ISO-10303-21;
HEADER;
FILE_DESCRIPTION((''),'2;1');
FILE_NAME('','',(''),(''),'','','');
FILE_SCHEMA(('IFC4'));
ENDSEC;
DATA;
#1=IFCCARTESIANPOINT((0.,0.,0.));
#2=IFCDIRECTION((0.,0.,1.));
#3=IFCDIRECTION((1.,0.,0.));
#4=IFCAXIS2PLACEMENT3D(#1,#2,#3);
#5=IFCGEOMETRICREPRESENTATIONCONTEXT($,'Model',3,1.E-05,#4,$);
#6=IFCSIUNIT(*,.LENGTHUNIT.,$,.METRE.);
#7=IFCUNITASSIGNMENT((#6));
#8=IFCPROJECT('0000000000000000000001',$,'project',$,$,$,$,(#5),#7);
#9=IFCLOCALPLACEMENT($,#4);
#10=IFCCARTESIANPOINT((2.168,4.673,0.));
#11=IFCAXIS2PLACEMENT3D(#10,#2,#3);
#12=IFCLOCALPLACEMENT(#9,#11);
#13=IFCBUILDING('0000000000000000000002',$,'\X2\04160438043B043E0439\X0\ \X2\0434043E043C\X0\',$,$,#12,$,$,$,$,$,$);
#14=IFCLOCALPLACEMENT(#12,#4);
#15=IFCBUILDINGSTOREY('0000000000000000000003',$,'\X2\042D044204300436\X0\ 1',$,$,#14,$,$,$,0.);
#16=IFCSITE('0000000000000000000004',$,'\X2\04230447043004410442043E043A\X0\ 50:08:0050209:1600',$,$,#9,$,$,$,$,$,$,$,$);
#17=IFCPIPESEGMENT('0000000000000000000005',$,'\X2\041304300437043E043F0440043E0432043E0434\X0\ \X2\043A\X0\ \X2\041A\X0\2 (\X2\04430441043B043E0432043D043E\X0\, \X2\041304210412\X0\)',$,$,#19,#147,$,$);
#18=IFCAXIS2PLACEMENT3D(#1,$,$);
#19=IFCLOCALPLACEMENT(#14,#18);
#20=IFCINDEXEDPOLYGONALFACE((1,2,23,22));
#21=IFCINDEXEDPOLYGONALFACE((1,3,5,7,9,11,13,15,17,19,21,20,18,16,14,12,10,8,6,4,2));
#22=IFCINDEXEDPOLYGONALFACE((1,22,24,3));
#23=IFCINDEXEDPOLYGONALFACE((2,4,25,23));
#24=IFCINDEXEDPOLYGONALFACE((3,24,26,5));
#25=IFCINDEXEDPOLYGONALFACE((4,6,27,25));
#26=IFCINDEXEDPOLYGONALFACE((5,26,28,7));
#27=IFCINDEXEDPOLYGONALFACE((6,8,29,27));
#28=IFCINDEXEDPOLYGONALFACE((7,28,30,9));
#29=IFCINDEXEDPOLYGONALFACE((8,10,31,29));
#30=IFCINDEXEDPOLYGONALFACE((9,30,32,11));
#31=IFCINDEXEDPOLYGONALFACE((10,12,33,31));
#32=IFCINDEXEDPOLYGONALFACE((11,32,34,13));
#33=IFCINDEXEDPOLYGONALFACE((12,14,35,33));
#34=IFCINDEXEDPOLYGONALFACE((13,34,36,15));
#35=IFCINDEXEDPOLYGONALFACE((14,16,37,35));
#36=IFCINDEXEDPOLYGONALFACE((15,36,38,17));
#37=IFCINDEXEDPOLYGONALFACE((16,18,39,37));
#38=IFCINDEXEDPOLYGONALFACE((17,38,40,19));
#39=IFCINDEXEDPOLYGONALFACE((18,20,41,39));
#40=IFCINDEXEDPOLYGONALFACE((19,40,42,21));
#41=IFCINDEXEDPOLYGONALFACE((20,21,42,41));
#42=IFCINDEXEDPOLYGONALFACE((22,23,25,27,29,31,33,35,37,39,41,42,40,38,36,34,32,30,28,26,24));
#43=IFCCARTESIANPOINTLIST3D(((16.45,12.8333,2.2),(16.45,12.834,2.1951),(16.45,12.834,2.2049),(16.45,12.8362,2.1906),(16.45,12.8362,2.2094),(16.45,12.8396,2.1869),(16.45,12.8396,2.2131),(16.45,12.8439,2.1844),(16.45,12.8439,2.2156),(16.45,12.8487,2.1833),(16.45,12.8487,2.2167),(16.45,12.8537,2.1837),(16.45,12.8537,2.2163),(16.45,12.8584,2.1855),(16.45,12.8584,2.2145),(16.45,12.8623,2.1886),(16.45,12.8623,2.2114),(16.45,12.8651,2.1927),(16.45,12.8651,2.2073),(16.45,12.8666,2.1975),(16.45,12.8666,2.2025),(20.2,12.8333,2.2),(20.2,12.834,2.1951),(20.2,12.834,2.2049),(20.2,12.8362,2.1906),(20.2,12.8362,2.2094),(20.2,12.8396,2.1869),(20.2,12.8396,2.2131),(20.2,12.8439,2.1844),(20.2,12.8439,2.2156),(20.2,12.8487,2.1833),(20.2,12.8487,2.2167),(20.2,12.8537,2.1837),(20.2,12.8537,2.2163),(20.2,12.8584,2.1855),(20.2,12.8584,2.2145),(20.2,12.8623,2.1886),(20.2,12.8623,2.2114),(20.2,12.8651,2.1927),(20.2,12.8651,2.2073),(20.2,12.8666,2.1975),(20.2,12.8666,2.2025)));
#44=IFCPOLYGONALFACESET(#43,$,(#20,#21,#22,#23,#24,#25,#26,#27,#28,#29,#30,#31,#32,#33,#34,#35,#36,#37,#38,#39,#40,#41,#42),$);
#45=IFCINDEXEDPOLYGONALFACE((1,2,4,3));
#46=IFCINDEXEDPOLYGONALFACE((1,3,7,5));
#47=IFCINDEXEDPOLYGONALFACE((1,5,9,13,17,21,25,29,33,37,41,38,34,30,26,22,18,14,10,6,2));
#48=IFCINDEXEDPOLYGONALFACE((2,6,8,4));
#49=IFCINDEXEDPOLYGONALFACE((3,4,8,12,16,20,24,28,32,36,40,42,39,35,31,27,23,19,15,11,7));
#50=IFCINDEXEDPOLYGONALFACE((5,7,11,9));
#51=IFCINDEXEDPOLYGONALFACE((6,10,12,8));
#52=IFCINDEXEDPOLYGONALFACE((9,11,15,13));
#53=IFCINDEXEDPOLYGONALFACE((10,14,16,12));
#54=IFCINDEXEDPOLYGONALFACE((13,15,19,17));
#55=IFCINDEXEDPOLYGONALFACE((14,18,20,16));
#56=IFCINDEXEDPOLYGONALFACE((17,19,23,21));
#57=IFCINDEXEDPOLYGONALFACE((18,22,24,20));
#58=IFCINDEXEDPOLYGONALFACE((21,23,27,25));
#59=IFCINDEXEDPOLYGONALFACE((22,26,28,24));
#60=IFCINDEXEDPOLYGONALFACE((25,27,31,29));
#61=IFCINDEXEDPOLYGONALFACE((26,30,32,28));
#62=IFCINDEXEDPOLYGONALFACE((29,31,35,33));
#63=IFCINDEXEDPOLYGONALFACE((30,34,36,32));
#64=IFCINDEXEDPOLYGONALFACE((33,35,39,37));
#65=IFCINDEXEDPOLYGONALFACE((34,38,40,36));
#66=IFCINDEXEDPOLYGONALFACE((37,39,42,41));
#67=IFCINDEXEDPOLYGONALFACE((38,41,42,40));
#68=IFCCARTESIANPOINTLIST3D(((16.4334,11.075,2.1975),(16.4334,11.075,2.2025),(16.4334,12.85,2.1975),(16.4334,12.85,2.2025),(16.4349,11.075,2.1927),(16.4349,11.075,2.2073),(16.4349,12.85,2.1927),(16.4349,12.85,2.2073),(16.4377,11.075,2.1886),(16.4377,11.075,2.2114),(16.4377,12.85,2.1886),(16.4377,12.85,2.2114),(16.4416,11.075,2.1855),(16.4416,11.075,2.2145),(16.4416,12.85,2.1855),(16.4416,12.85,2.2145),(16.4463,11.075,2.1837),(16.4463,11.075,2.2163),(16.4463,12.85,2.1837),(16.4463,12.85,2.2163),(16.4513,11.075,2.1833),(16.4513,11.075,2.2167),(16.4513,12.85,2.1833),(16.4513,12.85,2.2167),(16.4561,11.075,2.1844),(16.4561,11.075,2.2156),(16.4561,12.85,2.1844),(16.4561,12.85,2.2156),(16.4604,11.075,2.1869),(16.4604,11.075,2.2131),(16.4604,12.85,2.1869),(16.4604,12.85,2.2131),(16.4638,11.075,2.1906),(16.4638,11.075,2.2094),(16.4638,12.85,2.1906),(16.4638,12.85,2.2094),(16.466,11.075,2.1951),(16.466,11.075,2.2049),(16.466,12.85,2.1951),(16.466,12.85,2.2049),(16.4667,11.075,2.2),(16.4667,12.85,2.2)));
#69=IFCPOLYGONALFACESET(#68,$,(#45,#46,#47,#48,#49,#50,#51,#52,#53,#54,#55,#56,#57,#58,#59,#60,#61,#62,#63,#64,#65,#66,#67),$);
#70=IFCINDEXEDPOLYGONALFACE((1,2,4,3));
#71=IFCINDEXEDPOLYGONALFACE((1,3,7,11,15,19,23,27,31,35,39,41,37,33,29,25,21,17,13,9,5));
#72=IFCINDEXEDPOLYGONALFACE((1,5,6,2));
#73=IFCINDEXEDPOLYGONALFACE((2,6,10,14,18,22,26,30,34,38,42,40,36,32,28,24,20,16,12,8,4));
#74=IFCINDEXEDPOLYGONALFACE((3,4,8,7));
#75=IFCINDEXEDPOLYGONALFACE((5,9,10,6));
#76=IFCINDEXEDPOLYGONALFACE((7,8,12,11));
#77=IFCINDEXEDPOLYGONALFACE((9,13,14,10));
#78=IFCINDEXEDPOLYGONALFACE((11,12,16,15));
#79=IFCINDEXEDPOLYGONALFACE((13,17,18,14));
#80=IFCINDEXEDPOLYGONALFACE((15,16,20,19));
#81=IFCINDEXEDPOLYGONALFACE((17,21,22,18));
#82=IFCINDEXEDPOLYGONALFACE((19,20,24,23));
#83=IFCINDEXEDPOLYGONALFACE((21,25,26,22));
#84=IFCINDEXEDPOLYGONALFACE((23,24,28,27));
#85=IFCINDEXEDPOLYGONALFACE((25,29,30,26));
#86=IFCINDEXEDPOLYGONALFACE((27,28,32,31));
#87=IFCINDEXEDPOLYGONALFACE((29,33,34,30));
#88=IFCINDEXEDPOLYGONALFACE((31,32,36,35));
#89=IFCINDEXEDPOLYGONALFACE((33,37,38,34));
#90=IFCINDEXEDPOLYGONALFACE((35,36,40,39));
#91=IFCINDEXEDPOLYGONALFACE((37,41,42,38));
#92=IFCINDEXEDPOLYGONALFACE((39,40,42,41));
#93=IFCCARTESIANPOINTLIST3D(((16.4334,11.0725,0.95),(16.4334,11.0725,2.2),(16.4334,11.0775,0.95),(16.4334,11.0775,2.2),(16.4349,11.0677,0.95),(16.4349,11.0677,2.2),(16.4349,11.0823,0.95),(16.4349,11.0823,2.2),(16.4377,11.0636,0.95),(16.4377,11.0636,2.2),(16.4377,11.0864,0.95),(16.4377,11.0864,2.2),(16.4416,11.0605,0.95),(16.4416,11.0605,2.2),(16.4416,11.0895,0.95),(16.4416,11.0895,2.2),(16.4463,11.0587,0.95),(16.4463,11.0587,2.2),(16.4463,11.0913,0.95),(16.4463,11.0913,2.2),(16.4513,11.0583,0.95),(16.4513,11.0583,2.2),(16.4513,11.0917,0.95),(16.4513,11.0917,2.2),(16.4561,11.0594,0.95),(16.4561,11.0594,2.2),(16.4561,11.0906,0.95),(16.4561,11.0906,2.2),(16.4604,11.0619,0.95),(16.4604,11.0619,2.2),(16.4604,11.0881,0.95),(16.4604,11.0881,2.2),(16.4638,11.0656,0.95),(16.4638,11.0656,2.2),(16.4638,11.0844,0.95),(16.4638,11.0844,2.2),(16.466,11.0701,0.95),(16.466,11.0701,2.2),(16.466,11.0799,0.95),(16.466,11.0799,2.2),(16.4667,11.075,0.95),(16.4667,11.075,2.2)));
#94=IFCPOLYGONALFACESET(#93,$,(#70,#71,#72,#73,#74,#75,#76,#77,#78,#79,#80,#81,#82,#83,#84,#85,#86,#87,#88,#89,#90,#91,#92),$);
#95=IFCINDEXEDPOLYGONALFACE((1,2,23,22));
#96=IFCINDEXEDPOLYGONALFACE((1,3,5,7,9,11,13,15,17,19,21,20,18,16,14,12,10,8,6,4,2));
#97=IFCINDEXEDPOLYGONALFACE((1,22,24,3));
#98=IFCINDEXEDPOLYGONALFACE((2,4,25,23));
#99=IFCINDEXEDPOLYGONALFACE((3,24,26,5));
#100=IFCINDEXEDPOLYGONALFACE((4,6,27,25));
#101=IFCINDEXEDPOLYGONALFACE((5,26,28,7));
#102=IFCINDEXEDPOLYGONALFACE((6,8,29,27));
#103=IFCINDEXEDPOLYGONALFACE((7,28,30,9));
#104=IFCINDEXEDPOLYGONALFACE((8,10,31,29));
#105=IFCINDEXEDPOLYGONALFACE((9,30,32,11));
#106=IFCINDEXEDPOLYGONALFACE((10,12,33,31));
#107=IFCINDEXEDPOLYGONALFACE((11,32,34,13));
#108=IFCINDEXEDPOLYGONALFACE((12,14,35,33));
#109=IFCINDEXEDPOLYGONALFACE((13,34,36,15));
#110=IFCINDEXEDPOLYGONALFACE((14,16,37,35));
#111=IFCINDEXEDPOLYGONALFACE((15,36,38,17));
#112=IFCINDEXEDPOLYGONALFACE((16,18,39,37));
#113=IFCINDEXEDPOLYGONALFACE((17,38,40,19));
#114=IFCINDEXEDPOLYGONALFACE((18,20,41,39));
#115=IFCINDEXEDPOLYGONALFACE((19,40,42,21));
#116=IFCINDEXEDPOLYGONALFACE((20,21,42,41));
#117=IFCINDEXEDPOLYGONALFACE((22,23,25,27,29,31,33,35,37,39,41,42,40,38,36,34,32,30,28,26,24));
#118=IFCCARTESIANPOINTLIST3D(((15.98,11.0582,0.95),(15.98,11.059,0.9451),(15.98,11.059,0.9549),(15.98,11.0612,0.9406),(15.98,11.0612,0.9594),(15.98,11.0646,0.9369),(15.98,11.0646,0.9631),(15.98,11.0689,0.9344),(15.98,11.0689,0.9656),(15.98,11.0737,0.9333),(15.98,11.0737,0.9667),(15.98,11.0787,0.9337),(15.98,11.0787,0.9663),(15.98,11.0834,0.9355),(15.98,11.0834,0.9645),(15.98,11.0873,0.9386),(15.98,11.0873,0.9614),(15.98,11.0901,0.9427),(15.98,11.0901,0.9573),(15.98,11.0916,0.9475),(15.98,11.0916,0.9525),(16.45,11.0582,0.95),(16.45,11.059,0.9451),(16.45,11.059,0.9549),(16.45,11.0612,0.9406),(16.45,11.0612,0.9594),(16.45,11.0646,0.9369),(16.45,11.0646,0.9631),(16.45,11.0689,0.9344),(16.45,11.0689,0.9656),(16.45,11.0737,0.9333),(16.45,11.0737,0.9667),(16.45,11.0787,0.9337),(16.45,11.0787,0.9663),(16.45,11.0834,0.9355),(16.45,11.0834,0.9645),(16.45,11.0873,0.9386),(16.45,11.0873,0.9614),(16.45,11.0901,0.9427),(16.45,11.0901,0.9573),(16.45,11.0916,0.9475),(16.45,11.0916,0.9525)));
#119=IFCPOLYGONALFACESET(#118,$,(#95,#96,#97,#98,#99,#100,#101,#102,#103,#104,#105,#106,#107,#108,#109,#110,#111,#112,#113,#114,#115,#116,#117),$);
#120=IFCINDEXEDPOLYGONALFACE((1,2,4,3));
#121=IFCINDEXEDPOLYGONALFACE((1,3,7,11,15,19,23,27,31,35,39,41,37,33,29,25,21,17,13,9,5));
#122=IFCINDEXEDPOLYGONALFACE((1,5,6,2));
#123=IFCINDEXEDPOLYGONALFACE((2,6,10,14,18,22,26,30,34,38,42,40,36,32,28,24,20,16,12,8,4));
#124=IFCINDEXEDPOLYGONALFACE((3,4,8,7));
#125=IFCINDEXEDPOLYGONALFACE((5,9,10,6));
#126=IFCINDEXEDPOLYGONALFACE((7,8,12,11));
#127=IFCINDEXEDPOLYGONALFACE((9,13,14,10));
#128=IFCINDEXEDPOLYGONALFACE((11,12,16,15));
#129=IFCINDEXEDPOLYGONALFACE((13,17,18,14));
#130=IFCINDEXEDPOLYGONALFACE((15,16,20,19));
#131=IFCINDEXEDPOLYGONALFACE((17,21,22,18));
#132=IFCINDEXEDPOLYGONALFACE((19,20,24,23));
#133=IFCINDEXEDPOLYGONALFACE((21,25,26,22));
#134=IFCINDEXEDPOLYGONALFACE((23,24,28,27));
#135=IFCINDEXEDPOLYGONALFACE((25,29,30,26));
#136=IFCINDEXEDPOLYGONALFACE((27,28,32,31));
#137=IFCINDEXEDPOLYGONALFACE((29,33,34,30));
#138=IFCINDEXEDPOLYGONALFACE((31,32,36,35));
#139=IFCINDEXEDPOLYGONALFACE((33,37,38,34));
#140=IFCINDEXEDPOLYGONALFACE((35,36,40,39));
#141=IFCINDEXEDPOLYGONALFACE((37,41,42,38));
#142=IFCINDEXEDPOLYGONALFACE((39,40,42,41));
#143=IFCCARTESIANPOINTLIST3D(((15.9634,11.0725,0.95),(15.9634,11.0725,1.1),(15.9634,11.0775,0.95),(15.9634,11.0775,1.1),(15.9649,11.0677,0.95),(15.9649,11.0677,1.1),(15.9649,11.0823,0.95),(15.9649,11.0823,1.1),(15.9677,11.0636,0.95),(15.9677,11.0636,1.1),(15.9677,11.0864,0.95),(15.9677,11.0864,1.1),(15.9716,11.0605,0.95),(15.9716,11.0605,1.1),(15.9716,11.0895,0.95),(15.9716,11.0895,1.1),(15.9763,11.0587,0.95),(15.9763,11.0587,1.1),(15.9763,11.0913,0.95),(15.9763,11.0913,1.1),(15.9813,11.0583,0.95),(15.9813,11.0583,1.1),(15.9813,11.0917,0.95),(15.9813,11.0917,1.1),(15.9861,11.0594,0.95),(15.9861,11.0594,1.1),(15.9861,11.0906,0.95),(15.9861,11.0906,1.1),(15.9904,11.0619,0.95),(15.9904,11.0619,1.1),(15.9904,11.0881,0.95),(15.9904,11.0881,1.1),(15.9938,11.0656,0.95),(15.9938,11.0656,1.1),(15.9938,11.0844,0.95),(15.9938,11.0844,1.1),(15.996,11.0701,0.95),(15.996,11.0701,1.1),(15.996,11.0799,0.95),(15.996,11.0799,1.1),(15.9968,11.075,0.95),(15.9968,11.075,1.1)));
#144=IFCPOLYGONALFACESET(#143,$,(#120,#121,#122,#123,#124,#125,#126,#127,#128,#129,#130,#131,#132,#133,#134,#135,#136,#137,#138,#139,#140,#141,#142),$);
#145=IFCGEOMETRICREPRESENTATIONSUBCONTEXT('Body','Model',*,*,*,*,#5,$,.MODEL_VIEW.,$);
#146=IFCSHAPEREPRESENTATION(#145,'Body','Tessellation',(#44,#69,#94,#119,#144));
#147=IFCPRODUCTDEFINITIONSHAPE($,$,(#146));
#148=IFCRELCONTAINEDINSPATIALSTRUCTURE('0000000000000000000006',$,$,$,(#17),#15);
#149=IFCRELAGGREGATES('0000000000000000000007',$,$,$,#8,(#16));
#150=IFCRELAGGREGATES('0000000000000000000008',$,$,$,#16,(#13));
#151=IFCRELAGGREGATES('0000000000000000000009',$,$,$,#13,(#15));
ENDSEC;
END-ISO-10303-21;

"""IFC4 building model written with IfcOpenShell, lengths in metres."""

from ifc_helpers import new_model, si_unit, frame, origin_with_axes, origin_2d, place, context, subcontext, project, spatial, circle, extrude, element, save


model = new_model("IFC4")

# Units and contexts
model_context = context("Model", 3, precision=1e-05, world=origin_with_axes())
body_context = subcontext(model_context, "Body", "Model", "MODEL_VIEW")
ifc_project = project(units=[si_unit("LENGTHUNIT", "METRE")], contexts=[model_context])

# Site, building, storey
site_placement = place(None, origin_with_axes())
site = spatial("IfcSite", under=ifc_project, at=site_placement, Name="Участок 50:08:0050209:1600")
building_placement = place(site_placement, frame((2.168, 4.673, 0.0), z_axis=(0.0, 0.0, 1.0), x_axis=(1.0, 0.0, 0.0)))
building = spatial("IfcBuilding", under=site, at=building_placement, Name="Жилой дом")
storey_placement = place(building_placement, origin_with_axes())
storey = spatial("IfcBuildingStorey", under=building, at=storey_placement, Name="Этаж 1", Elevation=0.0)

# Pipe segment
pipe_segment_1_placement = place(storey_placement, origin_with_axes())
element("IfcPipeSegment", 1, at=pipe_segment_1_placement, inside=storey, Name="Газопровод к К2 (условно, ГСВ)", context=body_context, shape_type="SweptSolid", body=[
    extrude(circle(Radius=0.0168, at=origin_2d()), frame((20.2, 12.85, 2.2), z_axis=(-1.0, 0.0, 0.0), x_axis=(0.0, -1.0, 0.0)), (0.0, 0.0, 1.0), 3.75),
    extrude(circle(Radius=0.0168, at=origin_2d()), frame((16.45, 12.85, 2.2), z_axis=(0.0, -1.0, 0.0), x_axis=(1.0, 0.0, 0.0)), (0.0, 0.0, 1.0), 1.775),
    extrude(circle(Radius=0.0168, at=origin_2d()), frame((16.45, 11.075, 2.2), z_axis=(0.0, 0.0, -1.0), x_axis=(1.0, 0.0, 0.0)), (0.0, 0.0, 1.0), 1.25),
    extrude(circle(Radius=0.0168, at=origin_2d()), frame((16.45, 11.075, 0.95), z_axis=(-1.0, 0.0, 0.0), x_axis=(0.0, -1.0, 0.0)), (0.0, 0.0, 1.0), 0.47),
    extrude(circle(Radius=0.0168, at=origin_2d()), frame((15.98, 11.075, 0.95), z_axis=(0.0, 0.0, 1.0), x_axis=(1.0, 0.0, 0.0)), (0.0, 0.0, 1.0), 0.15),
])

save(model, "model.ifc")
